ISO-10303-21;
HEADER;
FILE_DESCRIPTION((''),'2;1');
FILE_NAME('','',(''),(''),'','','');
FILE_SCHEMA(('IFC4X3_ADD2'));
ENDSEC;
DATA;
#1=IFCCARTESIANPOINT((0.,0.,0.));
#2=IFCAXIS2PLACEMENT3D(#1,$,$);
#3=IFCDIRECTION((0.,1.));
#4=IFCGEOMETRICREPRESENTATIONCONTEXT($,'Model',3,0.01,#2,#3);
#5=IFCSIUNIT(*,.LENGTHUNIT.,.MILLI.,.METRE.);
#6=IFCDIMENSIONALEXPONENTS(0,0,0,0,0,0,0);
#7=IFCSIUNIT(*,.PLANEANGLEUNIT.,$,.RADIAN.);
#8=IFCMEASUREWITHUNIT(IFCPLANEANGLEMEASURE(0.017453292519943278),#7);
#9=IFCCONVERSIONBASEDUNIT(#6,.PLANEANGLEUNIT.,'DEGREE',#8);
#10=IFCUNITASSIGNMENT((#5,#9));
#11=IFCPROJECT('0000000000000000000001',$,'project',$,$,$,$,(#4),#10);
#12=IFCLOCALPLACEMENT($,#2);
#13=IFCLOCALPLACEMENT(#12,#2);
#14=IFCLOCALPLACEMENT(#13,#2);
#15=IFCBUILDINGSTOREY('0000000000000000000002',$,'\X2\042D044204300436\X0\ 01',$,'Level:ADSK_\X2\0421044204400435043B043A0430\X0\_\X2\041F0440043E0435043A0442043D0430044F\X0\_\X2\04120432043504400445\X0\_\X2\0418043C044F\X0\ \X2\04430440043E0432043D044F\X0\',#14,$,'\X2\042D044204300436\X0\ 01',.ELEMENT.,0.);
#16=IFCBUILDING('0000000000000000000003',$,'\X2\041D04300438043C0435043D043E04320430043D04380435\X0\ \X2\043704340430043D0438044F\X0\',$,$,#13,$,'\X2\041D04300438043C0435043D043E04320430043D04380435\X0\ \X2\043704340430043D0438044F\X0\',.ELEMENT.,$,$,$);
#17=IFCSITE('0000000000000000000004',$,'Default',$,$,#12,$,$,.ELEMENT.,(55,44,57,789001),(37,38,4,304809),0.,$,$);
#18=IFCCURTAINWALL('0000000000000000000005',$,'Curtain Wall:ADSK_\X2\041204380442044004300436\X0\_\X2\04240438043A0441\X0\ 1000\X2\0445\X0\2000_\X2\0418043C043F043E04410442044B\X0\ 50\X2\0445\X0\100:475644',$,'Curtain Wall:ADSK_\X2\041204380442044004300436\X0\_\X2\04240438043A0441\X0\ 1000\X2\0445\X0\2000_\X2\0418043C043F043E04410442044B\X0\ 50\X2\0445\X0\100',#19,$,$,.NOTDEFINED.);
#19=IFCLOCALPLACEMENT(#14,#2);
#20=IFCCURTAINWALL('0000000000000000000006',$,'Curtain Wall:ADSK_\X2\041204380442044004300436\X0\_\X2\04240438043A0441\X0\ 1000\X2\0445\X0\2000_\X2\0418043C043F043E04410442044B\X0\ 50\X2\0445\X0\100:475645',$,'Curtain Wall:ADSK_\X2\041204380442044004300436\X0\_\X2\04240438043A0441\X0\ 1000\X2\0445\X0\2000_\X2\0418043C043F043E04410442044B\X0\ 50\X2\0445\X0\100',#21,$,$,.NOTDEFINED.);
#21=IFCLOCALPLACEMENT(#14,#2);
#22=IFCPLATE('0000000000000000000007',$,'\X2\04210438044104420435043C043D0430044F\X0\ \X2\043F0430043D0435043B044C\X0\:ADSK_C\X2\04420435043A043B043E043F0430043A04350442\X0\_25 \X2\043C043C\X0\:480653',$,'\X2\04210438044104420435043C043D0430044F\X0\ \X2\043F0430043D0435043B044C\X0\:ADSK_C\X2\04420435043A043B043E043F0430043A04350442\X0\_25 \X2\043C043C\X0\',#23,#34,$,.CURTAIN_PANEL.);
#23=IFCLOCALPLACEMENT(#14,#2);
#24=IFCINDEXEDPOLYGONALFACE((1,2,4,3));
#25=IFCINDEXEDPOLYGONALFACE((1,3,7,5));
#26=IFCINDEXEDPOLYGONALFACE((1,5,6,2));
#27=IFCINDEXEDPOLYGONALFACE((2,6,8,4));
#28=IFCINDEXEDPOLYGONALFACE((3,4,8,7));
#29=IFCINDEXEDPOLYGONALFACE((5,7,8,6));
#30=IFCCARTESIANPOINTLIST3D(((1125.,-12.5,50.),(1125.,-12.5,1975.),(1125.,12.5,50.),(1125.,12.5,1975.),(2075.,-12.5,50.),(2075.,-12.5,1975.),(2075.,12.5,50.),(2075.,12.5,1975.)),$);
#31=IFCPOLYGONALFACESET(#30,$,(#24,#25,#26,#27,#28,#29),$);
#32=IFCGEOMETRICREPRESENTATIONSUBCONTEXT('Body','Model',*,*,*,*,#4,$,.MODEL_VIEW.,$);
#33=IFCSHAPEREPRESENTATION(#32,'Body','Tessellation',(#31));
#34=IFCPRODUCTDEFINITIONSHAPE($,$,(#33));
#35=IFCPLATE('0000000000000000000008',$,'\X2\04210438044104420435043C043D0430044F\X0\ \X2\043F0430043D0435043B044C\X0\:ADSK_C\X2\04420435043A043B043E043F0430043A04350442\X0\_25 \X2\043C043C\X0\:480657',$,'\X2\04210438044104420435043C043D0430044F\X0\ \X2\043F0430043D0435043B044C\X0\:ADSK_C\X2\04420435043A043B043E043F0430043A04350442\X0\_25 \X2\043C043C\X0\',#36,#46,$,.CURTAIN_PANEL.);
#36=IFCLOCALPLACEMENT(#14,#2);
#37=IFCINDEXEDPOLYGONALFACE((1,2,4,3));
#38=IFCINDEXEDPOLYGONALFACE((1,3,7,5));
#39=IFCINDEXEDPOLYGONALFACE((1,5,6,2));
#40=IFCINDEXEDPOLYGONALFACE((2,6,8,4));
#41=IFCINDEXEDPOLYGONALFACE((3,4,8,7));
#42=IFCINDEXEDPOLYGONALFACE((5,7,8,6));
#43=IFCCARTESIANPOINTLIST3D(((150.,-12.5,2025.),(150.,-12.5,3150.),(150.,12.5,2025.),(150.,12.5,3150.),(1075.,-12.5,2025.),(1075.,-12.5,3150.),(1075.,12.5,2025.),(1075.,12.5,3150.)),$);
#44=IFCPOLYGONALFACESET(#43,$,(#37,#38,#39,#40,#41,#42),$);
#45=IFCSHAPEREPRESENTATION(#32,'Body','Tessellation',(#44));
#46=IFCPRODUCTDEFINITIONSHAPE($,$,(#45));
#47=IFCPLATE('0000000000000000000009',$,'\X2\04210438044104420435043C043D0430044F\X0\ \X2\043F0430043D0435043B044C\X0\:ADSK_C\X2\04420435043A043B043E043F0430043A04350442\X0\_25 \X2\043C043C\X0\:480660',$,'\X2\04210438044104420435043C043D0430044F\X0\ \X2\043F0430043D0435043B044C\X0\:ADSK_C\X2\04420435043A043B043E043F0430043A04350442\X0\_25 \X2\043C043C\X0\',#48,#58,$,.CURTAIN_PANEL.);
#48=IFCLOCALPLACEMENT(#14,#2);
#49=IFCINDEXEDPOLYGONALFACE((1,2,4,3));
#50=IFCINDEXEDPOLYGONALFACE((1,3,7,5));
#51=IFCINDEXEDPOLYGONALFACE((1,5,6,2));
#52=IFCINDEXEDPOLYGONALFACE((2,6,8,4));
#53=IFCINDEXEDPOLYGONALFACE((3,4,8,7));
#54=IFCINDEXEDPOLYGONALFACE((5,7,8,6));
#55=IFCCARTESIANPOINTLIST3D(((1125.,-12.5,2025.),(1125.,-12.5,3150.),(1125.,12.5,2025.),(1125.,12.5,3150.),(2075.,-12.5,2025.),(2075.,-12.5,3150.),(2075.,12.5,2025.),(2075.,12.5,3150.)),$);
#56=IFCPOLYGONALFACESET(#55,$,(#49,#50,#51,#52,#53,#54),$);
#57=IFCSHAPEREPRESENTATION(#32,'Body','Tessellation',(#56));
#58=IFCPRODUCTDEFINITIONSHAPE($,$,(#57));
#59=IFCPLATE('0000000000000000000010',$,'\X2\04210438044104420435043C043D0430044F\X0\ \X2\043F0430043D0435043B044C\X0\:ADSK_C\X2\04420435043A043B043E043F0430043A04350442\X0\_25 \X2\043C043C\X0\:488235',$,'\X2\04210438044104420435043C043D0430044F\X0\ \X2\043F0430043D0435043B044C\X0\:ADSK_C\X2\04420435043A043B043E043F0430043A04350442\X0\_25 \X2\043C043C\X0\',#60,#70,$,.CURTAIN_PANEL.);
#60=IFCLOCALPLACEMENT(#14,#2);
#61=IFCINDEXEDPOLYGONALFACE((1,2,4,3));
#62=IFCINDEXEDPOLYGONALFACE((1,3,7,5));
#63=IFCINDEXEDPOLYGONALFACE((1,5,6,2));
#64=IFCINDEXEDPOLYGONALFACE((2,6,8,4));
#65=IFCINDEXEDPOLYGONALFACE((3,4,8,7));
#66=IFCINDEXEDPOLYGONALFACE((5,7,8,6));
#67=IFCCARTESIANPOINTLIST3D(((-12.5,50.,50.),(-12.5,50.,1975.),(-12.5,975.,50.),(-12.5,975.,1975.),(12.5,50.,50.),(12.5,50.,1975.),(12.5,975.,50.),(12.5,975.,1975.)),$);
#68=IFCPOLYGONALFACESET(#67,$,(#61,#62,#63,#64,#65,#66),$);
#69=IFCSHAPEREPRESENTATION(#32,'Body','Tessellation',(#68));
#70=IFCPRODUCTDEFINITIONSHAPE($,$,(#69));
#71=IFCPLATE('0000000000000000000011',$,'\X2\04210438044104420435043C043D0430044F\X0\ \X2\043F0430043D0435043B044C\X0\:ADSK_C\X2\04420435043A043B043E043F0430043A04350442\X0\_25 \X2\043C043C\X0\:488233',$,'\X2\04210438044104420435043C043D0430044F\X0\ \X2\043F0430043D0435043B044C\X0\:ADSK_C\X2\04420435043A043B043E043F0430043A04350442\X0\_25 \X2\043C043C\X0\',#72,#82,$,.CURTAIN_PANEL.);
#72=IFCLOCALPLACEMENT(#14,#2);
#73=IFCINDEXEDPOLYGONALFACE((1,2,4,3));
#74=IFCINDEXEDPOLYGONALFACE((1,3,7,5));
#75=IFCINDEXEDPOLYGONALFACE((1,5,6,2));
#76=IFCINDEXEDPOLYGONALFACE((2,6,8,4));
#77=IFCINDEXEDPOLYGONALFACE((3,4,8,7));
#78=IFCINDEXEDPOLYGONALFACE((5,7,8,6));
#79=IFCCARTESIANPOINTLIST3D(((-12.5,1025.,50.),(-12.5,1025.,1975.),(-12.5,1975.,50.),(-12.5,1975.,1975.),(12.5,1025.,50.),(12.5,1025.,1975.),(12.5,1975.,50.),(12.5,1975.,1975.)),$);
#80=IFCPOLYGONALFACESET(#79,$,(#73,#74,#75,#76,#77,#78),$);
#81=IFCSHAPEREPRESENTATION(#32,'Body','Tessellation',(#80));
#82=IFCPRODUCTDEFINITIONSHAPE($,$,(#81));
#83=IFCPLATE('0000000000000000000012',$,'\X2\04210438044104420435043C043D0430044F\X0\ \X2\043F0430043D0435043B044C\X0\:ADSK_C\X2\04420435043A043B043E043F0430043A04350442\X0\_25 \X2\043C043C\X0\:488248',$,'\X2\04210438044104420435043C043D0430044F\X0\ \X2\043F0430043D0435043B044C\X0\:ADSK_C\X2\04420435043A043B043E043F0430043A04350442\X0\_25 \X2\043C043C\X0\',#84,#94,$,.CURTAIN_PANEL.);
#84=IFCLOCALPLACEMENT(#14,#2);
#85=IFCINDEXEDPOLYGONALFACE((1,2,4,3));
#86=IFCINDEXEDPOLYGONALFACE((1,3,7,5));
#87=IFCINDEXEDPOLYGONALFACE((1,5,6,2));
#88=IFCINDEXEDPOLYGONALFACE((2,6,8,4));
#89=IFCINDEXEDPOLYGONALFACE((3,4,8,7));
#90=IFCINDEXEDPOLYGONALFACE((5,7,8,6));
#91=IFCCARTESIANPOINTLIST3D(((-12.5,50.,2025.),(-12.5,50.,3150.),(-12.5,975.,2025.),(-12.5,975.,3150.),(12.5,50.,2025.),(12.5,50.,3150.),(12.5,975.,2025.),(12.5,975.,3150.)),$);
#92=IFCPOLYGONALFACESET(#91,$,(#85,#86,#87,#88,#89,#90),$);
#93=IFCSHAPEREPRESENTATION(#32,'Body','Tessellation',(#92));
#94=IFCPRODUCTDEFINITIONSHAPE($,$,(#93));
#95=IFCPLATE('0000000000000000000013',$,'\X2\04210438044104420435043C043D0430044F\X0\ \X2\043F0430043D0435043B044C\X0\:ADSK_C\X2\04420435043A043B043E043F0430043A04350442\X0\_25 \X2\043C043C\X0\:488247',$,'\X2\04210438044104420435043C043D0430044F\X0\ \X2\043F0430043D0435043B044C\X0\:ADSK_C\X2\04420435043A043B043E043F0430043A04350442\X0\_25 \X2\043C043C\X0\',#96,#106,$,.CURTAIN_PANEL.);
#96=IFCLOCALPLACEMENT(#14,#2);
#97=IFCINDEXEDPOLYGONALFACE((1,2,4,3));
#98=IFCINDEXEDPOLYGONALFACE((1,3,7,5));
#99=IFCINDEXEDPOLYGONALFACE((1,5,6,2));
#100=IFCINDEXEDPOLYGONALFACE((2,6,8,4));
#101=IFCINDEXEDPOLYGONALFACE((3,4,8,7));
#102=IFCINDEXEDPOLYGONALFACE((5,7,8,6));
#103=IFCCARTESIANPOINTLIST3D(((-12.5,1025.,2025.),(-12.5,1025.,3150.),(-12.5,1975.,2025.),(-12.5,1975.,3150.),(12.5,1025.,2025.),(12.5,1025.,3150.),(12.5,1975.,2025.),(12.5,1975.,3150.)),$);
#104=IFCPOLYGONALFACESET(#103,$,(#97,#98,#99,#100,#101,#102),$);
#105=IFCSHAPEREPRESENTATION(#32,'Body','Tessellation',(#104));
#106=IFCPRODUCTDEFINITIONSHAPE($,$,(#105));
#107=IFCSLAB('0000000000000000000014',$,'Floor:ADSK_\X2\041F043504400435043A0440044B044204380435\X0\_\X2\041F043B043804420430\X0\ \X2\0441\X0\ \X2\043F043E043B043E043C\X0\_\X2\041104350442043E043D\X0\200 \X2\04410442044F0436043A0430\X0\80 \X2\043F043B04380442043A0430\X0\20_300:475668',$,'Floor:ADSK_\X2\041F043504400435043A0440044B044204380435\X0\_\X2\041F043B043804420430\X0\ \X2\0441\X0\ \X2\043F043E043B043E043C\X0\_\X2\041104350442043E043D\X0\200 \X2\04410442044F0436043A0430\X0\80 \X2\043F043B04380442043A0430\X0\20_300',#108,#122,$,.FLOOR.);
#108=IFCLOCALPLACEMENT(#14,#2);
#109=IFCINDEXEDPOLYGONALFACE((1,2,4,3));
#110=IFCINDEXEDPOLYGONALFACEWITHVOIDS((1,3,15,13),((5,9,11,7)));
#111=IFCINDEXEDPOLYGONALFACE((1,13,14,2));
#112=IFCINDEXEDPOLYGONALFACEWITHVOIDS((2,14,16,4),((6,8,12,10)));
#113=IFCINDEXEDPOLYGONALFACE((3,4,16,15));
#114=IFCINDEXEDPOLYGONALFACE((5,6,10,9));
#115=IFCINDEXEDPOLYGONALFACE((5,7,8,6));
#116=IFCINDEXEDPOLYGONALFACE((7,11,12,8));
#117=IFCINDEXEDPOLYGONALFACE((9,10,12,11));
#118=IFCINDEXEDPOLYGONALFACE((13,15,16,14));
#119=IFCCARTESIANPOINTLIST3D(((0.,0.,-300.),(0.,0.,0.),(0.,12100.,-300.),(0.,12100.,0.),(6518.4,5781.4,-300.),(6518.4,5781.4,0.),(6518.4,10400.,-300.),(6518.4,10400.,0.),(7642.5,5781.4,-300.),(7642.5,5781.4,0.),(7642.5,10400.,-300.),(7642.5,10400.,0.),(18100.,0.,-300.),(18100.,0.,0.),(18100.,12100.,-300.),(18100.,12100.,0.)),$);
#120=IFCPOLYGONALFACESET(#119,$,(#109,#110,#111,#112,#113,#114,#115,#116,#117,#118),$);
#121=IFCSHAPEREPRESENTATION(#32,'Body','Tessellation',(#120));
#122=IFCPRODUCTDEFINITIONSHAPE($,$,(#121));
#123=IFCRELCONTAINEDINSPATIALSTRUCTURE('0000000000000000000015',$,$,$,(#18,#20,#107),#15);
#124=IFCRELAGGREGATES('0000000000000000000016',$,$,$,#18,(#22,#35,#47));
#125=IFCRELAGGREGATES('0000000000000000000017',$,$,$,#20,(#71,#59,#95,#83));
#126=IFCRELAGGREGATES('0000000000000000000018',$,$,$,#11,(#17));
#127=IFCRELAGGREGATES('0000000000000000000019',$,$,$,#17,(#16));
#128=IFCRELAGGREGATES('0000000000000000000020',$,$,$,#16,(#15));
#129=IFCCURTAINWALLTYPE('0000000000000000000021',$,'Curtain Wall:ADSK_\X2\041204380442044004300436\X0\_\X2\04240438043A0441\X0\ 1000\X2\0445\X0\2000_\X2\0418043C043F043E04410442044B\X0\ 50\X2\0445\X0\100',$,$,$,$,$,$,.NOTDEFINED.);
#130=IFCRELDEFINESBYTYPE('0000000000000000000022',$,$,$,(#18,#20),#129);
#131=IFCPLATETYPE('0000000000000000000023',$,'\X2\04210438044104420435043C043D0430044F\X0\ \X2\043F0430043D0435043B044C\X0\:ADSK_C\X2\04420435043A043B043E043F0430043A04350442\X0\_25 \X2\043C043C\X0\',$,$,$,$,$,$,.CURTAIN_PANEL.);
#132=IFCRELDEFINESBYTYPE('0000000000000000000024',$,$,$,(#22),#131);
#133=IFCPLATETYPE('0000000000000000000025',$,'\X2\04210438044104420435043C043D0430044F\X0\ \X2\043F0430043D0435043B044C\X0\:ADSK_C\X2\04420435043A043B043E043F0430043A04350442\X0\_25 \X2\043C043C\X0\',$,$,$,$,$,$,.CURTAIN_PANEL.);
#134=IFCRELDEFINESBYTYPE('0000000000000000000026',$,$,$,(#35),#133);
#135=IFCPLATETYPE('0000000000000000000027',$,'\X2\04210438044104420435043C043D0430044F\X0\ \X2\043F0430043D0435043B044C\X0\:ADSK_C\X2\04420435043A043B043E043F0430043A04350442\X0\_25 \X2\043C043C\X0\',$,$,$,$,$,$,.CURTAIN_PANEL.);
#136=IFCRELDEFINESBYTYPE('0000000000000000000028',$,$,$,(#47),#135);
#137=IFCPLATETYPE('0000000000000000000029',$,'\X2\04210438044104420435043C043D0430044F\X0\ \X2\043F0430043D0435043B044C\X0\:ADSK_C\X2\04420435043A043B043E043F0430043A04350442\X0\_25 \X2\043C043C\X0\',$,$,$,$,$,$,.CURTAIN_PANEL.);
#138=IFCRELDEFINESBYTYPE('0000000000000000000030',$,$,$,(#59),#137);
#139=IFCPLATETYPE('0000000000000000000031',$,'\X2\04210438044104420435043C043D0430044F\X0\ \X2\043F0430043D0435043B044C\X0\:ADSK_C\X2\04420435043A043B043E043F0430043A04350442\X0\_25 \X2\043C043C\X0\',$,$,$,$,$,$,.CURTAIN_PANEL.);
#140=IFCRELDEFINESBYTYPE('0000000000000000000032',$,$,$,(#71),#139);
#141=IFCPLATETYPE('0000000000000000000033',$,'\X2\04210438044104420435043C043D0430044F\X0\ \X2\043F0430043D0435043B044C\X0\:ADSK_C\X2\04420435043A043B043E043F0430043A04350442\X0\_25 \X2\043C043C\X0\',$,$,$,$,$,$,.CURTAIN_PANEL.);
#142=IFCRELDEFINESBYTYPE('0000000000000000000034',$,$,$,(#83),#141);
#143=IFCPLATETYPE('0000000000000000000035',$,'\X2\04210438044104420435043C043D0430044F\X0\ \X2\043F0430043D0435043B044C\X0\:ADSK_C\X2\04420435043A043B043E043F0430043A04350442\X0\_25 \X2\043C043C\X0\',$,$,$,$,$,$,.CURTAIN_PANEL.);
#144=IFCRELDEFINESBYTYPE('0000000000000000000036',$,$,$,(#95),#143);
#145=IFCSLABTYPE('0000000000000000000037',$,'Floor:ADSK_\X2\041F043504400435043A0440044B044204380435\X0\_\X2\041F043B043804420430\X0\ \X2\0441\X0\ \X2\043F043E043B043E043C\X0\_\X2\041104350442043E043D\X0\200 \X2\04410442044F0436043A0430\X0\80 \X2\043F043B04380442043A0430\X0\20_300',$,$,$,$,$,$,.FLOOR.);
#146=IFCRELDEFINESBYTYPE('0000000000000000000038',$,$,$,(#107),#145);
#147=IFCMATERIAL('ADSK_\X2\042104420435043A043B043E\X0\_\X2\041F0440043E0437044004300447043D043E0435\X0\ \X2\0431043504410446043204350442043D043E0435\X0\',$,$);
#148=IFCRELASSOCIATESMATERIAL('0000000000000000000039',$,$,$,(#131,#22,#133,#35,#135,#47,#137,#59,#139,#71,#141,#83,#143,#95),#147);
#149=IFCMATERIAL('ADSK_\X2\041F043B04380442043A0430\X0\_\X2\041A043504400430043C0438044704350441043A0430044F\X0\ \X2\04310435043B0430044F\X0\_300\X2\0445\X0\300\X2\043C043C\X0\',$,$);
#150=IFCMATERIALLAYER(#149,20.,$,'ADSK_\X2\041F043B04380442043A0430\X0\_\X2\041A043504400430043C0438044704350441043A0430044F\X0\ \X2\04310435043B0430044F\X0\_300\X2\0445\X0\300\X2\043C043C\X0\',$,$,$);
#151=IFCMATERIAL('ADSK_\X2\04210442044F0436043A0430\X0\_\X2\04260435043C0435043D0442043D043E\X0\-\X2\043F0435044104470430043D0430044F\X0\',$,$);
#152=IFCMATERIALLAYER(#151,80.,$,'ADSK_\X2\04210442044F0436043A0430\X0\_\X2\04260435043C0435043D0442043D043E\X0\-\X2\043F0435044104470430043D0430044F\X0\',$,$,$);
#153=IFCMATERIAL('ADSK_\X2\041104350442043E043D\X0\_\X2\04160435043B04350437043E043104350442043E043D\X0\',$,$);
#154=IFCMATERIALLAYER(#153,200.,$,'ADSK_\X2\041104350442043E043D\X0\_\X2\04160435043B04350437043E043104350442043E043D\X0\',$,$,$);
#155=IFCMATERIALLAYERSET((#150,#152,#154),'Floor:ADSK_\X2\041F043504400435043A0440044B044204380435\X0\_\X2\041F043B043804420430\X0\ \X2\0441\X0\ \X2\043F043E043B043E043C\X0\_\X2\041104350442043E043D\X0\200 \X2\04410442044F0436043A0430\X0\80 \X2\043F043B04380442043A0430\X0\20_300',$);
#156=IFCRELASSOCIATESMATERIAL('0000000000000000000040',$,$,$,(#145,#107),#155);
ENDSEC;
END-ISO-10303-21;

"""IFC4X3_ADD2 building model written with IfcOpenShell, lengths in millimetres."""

from ifc_helpers import new_model, entity, si_unit, converted_unit, direction, frame, frame_2d, origin, origin_2d_with_axis, place, context, subcontext, project, spatial, rectangle, extrude, boolean, source, transform, mapped, material, layer, layer_set, layer_usage, type_object, type_shapes, element, aggregate, save


model = new_model("IFC4X3_ADD2")

# Units and contexts
model_context = context("Model", 3, precision=0.01, world=origin(), true_north=direction((0.0, 1.0)))
body_context = subcontext(model_context, "Body", "Model", "MODEL_VIEW")
ifc_project = project(units=[si_unit("LENGTHUNIT", "METRE", prefix="MILLI"), converted_unit("PLANEANGLEUNIT", "DEGREE", entity("IfcPlaneAngleMeasure", 0.017453292519943278), si_unit("PLANEANGLEUNIT", "RADIAN"), dimensions=[0, 0, 0, 0, 0, 0, 0])], contexts=[model_context])

# Site, building, storey
site_placement = place(None, origin())
site = spatial("IfcSite", under=ifc_project, at=site_placement, Name="Default", CompositionType="ELEMENT", RefLatitude=(55, 44, 57, 789001), RefLongitude=(37, 38, 4, 304809), RefElevation=0.0)
building_placement = place(site_placement, origin())
building = spatial("IfcBuilding", under=site, at=building_placement, Name="Наименование здания", LongName="Наименование здания", CompositionType="ELEMENT")
storey_placement = place(building_placement, origin())
storey = spatial("IfcBuildingStorey", under=building, at=storey_placement, Name="Этаж 01", ObjectType="Level:ADSK_Стрелка_Проектная_Вверх_Имя уровня", LongName="Этаж 01", CompositionType="ELEMENT", Elevation=0.0)

# Curtain walls
curtain_wall_type = type_object("IfcCurtainWallType", Name="Curtain Wall:ADSK_Витраж_Фикс 1000х2000_Импосты 50х100", PredefinedType="NOTDEFINED")
curtain_wall_1_placement = place(storey_placement, origin())
curtain_wall_1 = element("IfcCurtainWall", 1, at=curtain_wall_1_placement, inside=storey, type_object=curtain_wall_type, Name="Curtain Wall:ADSK_Витраж_Фикс 1000х2000_Импосты 50х100:475644", ObjectType="Curtain Wall:ADSK_Витраж_Фикс 1000х2000_Импосты 50х100", PredefinedType="NOTDEFINED")
ifc_material_1 = material(Name="ADSK_Стекло_Прозрачное бесцветное")
curtain_wall_2_placement = place(storey_placement, origin())
curtain_wall_2 = element("IfcCurtainWall", 2, at=curtain_wall_2_placement, inside=storey, type_object=curtain_wall_type, Name="Curtain Wall:ADSK_Витраж_Фикс 1000х2000_Импосты 50х100:475645", ObjectType="Curtain Wall:ADSK_Витраж_Фикс 1000х2000_Импосты 50х100", PredefinedType="NOTDEFINED")

# Plates
plate_type_1 = type_object("IfcPlateType", Name="Системная панель:ADSK_Cтеклопакет_25 мм", PredefinedType="CURTAIN_PANEL", material=ifc_material_1)
shared_shape_1 = source(origin(), body_context, "Body", "SweptSolid", [
    extrude(rectangle(XDim=25.0, YDim=950.0, at=origin_2d_with_axis()), frame((0.0, 0.0, 0.0), z_axis=(0.0, 0.0, 1.0), x_axis=(0.0, 1.0, 0.0)), (0.0, 0.0, 1.0), 1925.0),
])
type_shapes(plate_type_1, [shared_shape_1])
plate_1_placement = place(curtain_wall_1_placement, frame((1600.0, 0.0, 50.0)))
plate_1 = element("IfcPlate", 3, at=plate_1_placement, type_object=plate_type_1, material=ifc_material_1, Name="Системная панель:ADSK_Cтеклопакет_25 мм:480653", ObjectType="Системная панель:ADSK_Cтеклопакет_25 мм", PredefinedType="CURTAIN_PANEL", context=body_context, shape_type="MappedRepresentation", body=[
    mapped(shared_shape_1, transform((0.0, 0.0, 0.0), scale=1.0)),
])
plate_type_2 = type_object("IfcPlateType", Name="Системная панель:ADSK_Cтеклопакет_25 мм", PredefinedType="CURTAIN_PANEL", material=ifc_material_1)
shared_shape_2 = source(origin(), body_context, "Body", "SweptSolid", [
    extrude(rectangle(XDim=25.0, YDim=925.0, at=origin_2d_with_axis()), frame((0.0, 0.0, 0.0), z_axis=(0.0, 0.0, 1.0), x_axis=(0.0, 1.0, 0.0)), (0.0, 0.0, 1.0), 1125.0),
])
type_shapes(plate_type_2, [shared_shape_2])
plate_2_placement = place(curtain_wall_1_placement, frame((612.5, 0.0, 2025.0)))
plate_2 = element("IfcPlate", 4, at=plate_2_placement, type_object=plate_type_2, material=ifc_material_1, Name="Системная панель:ADSK_Cтеклопакет_25 мм:480657", ObjectType="Системная панель:ADSK_Cтеклопакет_25 мм", PredefinedType="CURTAIN_PANEL", context=body_context, shape_type="MappedRepresentation", body=[
    mapped(shared_shape_2, transform((0.0, 0.0, 0.0), scale=1.0)),
])
plate_type_3 = type_object("IfcPlateType", Name="Системная панель:ADSK_Cтеклопакет_25 мм", PredefinedType="CURTAIN_PANEL", material=ifc_material_1)
shared_shape_3 = source(origin(), body_context, "Body", "SweptSolid", [
    extrude(rectangle(XDim=25.0, YDim=950.0, at=origin_2d_with_axis()), frame((0.0, 0.0, 0.0), z_axis=(0.0, 0.0, 1.0), x_axis=(0.0, 1.0, 0.0)), (0.0, 0.0, 1.0), 1125.0),
])
type_shapes(plate_type_3, [shared_shape_3])
plate_3_placement = place(curtain_wall_1_placement, frame((1600.0, 0.0, 2025.0)))
plate_3 = element("IfcPlate", 5, at=plate_3_placement, type_object=plate_type_3, material=ifc_material_1, Name="Системная панель:ADSK_Cтеклопакет_25 мм:480660", ObjectType="Системная панель:ADSK_Cтеклопакет_25 мм", PredefinedType="CURTAIN_PANEL", context=body_context, shape_type="MappedRepresentation", body=[
    mapped(shared_shape_3, transform((0.0, 0.0, 0.0), scale=1.0)),
])
aggregate(curtain_wall_1, [plate_1, plate_2, plate_3])
plate_type_4 = type_object("IfcPlateType", Name="Системная панель:ADSK_Cтеклопакет_25 мм", PredefinedType="CURTAIN_PANEL", material=ifc_material_1)
shared_shape_4 = source(origin(), body_context, "Body", "SweptSolid", [
    extrude(rectangle(XDim=25.0, YDim=925.0, at=origin_2d_with_axis()), frame((0.0, 0.0, 0.0), z_axis=(0.0, 0.0, 1.0), x_axis=(0.0, 1.0, 0.0)), (0.0, 0.0, 1.0), 1925.0),
])
type_shapes(plate_type_4, [shared_shape_4])
plate_4_placement = place(curtain_wall_2_placement, frame((0.0, 512.5, 50.0), z_axis=(0.0, 0.0, 1.0), x_axis=(0.0, -1.0, 0.0)))
plate_4 = element("IfcPlate", 6, at=plate_4_placement, type_object=plate_type_4, material=ifc_material_1, Name="Системная панель:ADSK_Cтеклопакет_25 мм:488235", ObjectType="Системная панель:ADSK_Cтеклопакет_25 мм", PredefinedType="CURTAIN_PANEL", context=body_context, shape_type="MappedRepresentation", body=[
    mapped(shared_shape_4, transform((0.0, 0.0, 0.0), scale=1.0)),
])
plate_type_5 = type_object("IfcPlateType", Name="Системная панель:ADSK_Cтеклопакет_25 мм", PredefinedType="CURTAIN_PANEL", material=ifc_material_1)
shared_shape_5 = source(origin(), body_context, "Body", "SweptSolid", [
    extrude(rectangle(XDim=25.0, YDim=950.0, at=origin_2d_with_axis()), frame((0.0, 0.0, 0.0), z_axis=(0.0, 0.0, 1.0), x_axis=(0.0, 1.0, 0.0)), (0.0, 0.0, 1.0), 1925.0),
])
type_shapes(plate_type_5, [shared_shape_5])
plate_5_placement = place(curtain_wall_2_placement, frame((0.0, 1500.0, 50.0), z_axis=(0.0, 0.0, 1.0), x_axis=(0.0, -1.0, 0.0)))
plate_5 = element("IfcPlate", 7, at=plate_5_placement, type_object=plate_type_5, material=ifc_material_1, Name="Системная панель:ADSK_Cтеклопакет_25 мм:488233", ObjectType="Системная панель:ADSK_Cтеклопакет_25 мм", PredefinedType="CURTAIN_PANEL", context=body_context, shape_type="MappedRepresentation", body=[
    mapped(shared_shape_5, transform((0.0, 0.0, 0.0), scale=1.0)),
])
plate_type_6 = type_object("IfcPlateType", Name="Системная панель:ADSK_Cтеклопакет_25 мм", PredefinedType="CURTAIN_PANEL", material=ifc_material_1)
shared_shape_6 = source(origin(), body_context, "Body", "SweptSolid", [
    extrude(rectangle(XDim=25.0, YDim=925.0, at=origin_2d_with_axis()), frame((0.0, 0.0, 0.0), z_axis=(0.0, 0.0, 1.0), x_axis=(0.0, 1.0, 0.0)), (0.0, 0.0, 1.0), 1125.0),
])
type_shapes(plate_type_6, [shared_shape_6])
plate_6_placement = place(curtain_wall_2_placement, frame((0.0, 512.5, 2025.0), z_axis=(0.0, 0.0, 1.0), x_axis=(0.0, -1.0, 0.0)))
plate_6 = element("IfcPlate", 8, at=plate_6_placement, type_object=plate_type_6, material=ifc_material_1, Name="Системная панель:ADSK_Cтеклопакет_25 мм:488248", ObjectType="Системная панель:ADSK_Cтеклопакет_25 мм", PredefinedType="CURTAIN_PANEL", context=body_context, shape_type="MappedRepresentation", body=[
    mapped(shared_shape_6, transform((0.0, 0.0, 0.0), scale=1.0)),
])
plate_type_7 = type_object("IfcPlateType", Name="Системная панель:ADSK_Cтеклопакет_25 мм", PredefinedType="CURTAIN_PANEL", material=ifc_material_1)
shared_shape_7 = source(origin(), body_context, "Body", "SweptSolid", [
    extrude(rectangle(XDim=25.0, YDim=950.0, at=origin_2d_with_axis()), frame((0.0, 0.0, 0.0), z_axis=(0.0, 0.0, 1.0), x_axis=(0.0, 1.0, 0.0)), (0.0, 0.0, 1.0), 1125.0),
])
type_shapes(plate_type_7, [shared_shape_7])
plate_7_placement = place(curtain_wall_2_placement, frame((0.0, 1500.0, 2025.0), z_axis=(0.0, 0.0, 1.0), x_axis=(0.0, -1.0, 0.0)))
plate_7 = element("IfcPlate", 9, at=plate_7_placement, type_object=plate_type_7, material=ifc_material_1, Name="Системная панель:ADSK_Cтеклопакет_25 мм:488247", ObjectType="Системная панель:ADSK_Cтеклопакет_25 мм", PredefinedType="CURTAIN_PANEL", context=body_context, shape_type="MappedRepresentation", body=[
    mapped(shared_shape_7, transform((0.0, 0.0, 0.0), scale=1.0)),
])
aggregate(curtain_wall_2, [plate_5, plate_4, plate_7, plate_6])

# Slab, opening
ifc_material_2 = material(Name="ADSK_Плитка_Керамическая белая_300х300мм")
ifc_layer_1 = layer(ifc_material_2, 20.0, Name="ADSK_Плитка_Керамическая белая_300х300мм")
ifc_material_3 = material(Name="ADSK_Стяжка_Цементно-песчаная")
ifc_layer_2 = layer(ifc_material_3, 80.0, Name="ADSK_Стяжка_Цементно-песчаная")
ifc_material_4 = material(Name="ADSK_Бетон_Железобетон")
ifc_layer_3 = layer(ifc_material_4, 200.0, Name="ADSK_Бетон_Железобетон")
ifc_layer_set = layer_set([ifc_layer_1, ifc_layer_2, ifc_layer_3], Name="Floor:ADSK_Перекрытие_Плита с полом_Бетон200 стяжка80 плитка20_300")
ifc_layer_usage = layer_usage(ifc_layer_set, "AXIS3", "POSITIVE", 0.0)
slab_type = type_object("IfcSlabType", Name="Floor:ADSK_Перекрытие_Плита с полом_Бетон200 стяжка80 плитка20_300", PredefinedType="FLOOR", material=ifc_layer_set)
slab_placement = place(storey_placement, origin())
slab = element("IfcSlab", 10, at=slab_placement, inside=storey, type_object=slab_type, material=ifc_layer_usage, Name="Floor:ADSK_Перекрытие_Плита с полом_Бетон200 стяжка80 плитка20_300:475668", ObjectType="Floor:ADSK_Перекрытие_Плита с полом_Бетон200 стяжка80 плитка20_300", PredefinedType="FLOOR", context=body_context, shape_type="SweptSolid", body=[
    boolean("DIFFERENCE", extrude(rectangle(XDim=12100.0, YDim=18100.0, at=origin_2d_with_axis()), frame((9050.0, 6050.0, 0.0), z_axis=(0.0, 0.0, -1.0), x_axis=(0.0, 1.0, 0.0)), (0.0, 0.0, 1.0), 300.0), extrude(rectangle(XDim=4618.6, YDim=1124.1, at=frame_2d((0.0, 0.0), x_axis=(1.0, 0.0))), frame((7080.5, 8090.7, 0.0), z_axis=(0.0, 0.0, -1.0), x_axis=(0.0, -1.0, 0.0)), (0.0, 0.0, 1.0), 300.0)),
])
opening_placement = place(slab_placement, origin())
element("IfcOpeningElement", 11, at=opening_placement, cuts=slab, PredefinedType="OPENING", context=body_context, shape_type="SweptSolid", body=[
    extrude(rectangle(XDim=4618.6, YDim=1124.1, at=frame_2d((0.0, 0.0), x_axis=(1.0, 0.0))), frame((7080.5, 8090.7, -300.0), z_axis=(0.0, 0.0, 1.0), x_axis=(0.0, 1.0, 0.0)), (0.0, 0.0, 1.0), 300.0),
])

save(model, "model.ifc")
